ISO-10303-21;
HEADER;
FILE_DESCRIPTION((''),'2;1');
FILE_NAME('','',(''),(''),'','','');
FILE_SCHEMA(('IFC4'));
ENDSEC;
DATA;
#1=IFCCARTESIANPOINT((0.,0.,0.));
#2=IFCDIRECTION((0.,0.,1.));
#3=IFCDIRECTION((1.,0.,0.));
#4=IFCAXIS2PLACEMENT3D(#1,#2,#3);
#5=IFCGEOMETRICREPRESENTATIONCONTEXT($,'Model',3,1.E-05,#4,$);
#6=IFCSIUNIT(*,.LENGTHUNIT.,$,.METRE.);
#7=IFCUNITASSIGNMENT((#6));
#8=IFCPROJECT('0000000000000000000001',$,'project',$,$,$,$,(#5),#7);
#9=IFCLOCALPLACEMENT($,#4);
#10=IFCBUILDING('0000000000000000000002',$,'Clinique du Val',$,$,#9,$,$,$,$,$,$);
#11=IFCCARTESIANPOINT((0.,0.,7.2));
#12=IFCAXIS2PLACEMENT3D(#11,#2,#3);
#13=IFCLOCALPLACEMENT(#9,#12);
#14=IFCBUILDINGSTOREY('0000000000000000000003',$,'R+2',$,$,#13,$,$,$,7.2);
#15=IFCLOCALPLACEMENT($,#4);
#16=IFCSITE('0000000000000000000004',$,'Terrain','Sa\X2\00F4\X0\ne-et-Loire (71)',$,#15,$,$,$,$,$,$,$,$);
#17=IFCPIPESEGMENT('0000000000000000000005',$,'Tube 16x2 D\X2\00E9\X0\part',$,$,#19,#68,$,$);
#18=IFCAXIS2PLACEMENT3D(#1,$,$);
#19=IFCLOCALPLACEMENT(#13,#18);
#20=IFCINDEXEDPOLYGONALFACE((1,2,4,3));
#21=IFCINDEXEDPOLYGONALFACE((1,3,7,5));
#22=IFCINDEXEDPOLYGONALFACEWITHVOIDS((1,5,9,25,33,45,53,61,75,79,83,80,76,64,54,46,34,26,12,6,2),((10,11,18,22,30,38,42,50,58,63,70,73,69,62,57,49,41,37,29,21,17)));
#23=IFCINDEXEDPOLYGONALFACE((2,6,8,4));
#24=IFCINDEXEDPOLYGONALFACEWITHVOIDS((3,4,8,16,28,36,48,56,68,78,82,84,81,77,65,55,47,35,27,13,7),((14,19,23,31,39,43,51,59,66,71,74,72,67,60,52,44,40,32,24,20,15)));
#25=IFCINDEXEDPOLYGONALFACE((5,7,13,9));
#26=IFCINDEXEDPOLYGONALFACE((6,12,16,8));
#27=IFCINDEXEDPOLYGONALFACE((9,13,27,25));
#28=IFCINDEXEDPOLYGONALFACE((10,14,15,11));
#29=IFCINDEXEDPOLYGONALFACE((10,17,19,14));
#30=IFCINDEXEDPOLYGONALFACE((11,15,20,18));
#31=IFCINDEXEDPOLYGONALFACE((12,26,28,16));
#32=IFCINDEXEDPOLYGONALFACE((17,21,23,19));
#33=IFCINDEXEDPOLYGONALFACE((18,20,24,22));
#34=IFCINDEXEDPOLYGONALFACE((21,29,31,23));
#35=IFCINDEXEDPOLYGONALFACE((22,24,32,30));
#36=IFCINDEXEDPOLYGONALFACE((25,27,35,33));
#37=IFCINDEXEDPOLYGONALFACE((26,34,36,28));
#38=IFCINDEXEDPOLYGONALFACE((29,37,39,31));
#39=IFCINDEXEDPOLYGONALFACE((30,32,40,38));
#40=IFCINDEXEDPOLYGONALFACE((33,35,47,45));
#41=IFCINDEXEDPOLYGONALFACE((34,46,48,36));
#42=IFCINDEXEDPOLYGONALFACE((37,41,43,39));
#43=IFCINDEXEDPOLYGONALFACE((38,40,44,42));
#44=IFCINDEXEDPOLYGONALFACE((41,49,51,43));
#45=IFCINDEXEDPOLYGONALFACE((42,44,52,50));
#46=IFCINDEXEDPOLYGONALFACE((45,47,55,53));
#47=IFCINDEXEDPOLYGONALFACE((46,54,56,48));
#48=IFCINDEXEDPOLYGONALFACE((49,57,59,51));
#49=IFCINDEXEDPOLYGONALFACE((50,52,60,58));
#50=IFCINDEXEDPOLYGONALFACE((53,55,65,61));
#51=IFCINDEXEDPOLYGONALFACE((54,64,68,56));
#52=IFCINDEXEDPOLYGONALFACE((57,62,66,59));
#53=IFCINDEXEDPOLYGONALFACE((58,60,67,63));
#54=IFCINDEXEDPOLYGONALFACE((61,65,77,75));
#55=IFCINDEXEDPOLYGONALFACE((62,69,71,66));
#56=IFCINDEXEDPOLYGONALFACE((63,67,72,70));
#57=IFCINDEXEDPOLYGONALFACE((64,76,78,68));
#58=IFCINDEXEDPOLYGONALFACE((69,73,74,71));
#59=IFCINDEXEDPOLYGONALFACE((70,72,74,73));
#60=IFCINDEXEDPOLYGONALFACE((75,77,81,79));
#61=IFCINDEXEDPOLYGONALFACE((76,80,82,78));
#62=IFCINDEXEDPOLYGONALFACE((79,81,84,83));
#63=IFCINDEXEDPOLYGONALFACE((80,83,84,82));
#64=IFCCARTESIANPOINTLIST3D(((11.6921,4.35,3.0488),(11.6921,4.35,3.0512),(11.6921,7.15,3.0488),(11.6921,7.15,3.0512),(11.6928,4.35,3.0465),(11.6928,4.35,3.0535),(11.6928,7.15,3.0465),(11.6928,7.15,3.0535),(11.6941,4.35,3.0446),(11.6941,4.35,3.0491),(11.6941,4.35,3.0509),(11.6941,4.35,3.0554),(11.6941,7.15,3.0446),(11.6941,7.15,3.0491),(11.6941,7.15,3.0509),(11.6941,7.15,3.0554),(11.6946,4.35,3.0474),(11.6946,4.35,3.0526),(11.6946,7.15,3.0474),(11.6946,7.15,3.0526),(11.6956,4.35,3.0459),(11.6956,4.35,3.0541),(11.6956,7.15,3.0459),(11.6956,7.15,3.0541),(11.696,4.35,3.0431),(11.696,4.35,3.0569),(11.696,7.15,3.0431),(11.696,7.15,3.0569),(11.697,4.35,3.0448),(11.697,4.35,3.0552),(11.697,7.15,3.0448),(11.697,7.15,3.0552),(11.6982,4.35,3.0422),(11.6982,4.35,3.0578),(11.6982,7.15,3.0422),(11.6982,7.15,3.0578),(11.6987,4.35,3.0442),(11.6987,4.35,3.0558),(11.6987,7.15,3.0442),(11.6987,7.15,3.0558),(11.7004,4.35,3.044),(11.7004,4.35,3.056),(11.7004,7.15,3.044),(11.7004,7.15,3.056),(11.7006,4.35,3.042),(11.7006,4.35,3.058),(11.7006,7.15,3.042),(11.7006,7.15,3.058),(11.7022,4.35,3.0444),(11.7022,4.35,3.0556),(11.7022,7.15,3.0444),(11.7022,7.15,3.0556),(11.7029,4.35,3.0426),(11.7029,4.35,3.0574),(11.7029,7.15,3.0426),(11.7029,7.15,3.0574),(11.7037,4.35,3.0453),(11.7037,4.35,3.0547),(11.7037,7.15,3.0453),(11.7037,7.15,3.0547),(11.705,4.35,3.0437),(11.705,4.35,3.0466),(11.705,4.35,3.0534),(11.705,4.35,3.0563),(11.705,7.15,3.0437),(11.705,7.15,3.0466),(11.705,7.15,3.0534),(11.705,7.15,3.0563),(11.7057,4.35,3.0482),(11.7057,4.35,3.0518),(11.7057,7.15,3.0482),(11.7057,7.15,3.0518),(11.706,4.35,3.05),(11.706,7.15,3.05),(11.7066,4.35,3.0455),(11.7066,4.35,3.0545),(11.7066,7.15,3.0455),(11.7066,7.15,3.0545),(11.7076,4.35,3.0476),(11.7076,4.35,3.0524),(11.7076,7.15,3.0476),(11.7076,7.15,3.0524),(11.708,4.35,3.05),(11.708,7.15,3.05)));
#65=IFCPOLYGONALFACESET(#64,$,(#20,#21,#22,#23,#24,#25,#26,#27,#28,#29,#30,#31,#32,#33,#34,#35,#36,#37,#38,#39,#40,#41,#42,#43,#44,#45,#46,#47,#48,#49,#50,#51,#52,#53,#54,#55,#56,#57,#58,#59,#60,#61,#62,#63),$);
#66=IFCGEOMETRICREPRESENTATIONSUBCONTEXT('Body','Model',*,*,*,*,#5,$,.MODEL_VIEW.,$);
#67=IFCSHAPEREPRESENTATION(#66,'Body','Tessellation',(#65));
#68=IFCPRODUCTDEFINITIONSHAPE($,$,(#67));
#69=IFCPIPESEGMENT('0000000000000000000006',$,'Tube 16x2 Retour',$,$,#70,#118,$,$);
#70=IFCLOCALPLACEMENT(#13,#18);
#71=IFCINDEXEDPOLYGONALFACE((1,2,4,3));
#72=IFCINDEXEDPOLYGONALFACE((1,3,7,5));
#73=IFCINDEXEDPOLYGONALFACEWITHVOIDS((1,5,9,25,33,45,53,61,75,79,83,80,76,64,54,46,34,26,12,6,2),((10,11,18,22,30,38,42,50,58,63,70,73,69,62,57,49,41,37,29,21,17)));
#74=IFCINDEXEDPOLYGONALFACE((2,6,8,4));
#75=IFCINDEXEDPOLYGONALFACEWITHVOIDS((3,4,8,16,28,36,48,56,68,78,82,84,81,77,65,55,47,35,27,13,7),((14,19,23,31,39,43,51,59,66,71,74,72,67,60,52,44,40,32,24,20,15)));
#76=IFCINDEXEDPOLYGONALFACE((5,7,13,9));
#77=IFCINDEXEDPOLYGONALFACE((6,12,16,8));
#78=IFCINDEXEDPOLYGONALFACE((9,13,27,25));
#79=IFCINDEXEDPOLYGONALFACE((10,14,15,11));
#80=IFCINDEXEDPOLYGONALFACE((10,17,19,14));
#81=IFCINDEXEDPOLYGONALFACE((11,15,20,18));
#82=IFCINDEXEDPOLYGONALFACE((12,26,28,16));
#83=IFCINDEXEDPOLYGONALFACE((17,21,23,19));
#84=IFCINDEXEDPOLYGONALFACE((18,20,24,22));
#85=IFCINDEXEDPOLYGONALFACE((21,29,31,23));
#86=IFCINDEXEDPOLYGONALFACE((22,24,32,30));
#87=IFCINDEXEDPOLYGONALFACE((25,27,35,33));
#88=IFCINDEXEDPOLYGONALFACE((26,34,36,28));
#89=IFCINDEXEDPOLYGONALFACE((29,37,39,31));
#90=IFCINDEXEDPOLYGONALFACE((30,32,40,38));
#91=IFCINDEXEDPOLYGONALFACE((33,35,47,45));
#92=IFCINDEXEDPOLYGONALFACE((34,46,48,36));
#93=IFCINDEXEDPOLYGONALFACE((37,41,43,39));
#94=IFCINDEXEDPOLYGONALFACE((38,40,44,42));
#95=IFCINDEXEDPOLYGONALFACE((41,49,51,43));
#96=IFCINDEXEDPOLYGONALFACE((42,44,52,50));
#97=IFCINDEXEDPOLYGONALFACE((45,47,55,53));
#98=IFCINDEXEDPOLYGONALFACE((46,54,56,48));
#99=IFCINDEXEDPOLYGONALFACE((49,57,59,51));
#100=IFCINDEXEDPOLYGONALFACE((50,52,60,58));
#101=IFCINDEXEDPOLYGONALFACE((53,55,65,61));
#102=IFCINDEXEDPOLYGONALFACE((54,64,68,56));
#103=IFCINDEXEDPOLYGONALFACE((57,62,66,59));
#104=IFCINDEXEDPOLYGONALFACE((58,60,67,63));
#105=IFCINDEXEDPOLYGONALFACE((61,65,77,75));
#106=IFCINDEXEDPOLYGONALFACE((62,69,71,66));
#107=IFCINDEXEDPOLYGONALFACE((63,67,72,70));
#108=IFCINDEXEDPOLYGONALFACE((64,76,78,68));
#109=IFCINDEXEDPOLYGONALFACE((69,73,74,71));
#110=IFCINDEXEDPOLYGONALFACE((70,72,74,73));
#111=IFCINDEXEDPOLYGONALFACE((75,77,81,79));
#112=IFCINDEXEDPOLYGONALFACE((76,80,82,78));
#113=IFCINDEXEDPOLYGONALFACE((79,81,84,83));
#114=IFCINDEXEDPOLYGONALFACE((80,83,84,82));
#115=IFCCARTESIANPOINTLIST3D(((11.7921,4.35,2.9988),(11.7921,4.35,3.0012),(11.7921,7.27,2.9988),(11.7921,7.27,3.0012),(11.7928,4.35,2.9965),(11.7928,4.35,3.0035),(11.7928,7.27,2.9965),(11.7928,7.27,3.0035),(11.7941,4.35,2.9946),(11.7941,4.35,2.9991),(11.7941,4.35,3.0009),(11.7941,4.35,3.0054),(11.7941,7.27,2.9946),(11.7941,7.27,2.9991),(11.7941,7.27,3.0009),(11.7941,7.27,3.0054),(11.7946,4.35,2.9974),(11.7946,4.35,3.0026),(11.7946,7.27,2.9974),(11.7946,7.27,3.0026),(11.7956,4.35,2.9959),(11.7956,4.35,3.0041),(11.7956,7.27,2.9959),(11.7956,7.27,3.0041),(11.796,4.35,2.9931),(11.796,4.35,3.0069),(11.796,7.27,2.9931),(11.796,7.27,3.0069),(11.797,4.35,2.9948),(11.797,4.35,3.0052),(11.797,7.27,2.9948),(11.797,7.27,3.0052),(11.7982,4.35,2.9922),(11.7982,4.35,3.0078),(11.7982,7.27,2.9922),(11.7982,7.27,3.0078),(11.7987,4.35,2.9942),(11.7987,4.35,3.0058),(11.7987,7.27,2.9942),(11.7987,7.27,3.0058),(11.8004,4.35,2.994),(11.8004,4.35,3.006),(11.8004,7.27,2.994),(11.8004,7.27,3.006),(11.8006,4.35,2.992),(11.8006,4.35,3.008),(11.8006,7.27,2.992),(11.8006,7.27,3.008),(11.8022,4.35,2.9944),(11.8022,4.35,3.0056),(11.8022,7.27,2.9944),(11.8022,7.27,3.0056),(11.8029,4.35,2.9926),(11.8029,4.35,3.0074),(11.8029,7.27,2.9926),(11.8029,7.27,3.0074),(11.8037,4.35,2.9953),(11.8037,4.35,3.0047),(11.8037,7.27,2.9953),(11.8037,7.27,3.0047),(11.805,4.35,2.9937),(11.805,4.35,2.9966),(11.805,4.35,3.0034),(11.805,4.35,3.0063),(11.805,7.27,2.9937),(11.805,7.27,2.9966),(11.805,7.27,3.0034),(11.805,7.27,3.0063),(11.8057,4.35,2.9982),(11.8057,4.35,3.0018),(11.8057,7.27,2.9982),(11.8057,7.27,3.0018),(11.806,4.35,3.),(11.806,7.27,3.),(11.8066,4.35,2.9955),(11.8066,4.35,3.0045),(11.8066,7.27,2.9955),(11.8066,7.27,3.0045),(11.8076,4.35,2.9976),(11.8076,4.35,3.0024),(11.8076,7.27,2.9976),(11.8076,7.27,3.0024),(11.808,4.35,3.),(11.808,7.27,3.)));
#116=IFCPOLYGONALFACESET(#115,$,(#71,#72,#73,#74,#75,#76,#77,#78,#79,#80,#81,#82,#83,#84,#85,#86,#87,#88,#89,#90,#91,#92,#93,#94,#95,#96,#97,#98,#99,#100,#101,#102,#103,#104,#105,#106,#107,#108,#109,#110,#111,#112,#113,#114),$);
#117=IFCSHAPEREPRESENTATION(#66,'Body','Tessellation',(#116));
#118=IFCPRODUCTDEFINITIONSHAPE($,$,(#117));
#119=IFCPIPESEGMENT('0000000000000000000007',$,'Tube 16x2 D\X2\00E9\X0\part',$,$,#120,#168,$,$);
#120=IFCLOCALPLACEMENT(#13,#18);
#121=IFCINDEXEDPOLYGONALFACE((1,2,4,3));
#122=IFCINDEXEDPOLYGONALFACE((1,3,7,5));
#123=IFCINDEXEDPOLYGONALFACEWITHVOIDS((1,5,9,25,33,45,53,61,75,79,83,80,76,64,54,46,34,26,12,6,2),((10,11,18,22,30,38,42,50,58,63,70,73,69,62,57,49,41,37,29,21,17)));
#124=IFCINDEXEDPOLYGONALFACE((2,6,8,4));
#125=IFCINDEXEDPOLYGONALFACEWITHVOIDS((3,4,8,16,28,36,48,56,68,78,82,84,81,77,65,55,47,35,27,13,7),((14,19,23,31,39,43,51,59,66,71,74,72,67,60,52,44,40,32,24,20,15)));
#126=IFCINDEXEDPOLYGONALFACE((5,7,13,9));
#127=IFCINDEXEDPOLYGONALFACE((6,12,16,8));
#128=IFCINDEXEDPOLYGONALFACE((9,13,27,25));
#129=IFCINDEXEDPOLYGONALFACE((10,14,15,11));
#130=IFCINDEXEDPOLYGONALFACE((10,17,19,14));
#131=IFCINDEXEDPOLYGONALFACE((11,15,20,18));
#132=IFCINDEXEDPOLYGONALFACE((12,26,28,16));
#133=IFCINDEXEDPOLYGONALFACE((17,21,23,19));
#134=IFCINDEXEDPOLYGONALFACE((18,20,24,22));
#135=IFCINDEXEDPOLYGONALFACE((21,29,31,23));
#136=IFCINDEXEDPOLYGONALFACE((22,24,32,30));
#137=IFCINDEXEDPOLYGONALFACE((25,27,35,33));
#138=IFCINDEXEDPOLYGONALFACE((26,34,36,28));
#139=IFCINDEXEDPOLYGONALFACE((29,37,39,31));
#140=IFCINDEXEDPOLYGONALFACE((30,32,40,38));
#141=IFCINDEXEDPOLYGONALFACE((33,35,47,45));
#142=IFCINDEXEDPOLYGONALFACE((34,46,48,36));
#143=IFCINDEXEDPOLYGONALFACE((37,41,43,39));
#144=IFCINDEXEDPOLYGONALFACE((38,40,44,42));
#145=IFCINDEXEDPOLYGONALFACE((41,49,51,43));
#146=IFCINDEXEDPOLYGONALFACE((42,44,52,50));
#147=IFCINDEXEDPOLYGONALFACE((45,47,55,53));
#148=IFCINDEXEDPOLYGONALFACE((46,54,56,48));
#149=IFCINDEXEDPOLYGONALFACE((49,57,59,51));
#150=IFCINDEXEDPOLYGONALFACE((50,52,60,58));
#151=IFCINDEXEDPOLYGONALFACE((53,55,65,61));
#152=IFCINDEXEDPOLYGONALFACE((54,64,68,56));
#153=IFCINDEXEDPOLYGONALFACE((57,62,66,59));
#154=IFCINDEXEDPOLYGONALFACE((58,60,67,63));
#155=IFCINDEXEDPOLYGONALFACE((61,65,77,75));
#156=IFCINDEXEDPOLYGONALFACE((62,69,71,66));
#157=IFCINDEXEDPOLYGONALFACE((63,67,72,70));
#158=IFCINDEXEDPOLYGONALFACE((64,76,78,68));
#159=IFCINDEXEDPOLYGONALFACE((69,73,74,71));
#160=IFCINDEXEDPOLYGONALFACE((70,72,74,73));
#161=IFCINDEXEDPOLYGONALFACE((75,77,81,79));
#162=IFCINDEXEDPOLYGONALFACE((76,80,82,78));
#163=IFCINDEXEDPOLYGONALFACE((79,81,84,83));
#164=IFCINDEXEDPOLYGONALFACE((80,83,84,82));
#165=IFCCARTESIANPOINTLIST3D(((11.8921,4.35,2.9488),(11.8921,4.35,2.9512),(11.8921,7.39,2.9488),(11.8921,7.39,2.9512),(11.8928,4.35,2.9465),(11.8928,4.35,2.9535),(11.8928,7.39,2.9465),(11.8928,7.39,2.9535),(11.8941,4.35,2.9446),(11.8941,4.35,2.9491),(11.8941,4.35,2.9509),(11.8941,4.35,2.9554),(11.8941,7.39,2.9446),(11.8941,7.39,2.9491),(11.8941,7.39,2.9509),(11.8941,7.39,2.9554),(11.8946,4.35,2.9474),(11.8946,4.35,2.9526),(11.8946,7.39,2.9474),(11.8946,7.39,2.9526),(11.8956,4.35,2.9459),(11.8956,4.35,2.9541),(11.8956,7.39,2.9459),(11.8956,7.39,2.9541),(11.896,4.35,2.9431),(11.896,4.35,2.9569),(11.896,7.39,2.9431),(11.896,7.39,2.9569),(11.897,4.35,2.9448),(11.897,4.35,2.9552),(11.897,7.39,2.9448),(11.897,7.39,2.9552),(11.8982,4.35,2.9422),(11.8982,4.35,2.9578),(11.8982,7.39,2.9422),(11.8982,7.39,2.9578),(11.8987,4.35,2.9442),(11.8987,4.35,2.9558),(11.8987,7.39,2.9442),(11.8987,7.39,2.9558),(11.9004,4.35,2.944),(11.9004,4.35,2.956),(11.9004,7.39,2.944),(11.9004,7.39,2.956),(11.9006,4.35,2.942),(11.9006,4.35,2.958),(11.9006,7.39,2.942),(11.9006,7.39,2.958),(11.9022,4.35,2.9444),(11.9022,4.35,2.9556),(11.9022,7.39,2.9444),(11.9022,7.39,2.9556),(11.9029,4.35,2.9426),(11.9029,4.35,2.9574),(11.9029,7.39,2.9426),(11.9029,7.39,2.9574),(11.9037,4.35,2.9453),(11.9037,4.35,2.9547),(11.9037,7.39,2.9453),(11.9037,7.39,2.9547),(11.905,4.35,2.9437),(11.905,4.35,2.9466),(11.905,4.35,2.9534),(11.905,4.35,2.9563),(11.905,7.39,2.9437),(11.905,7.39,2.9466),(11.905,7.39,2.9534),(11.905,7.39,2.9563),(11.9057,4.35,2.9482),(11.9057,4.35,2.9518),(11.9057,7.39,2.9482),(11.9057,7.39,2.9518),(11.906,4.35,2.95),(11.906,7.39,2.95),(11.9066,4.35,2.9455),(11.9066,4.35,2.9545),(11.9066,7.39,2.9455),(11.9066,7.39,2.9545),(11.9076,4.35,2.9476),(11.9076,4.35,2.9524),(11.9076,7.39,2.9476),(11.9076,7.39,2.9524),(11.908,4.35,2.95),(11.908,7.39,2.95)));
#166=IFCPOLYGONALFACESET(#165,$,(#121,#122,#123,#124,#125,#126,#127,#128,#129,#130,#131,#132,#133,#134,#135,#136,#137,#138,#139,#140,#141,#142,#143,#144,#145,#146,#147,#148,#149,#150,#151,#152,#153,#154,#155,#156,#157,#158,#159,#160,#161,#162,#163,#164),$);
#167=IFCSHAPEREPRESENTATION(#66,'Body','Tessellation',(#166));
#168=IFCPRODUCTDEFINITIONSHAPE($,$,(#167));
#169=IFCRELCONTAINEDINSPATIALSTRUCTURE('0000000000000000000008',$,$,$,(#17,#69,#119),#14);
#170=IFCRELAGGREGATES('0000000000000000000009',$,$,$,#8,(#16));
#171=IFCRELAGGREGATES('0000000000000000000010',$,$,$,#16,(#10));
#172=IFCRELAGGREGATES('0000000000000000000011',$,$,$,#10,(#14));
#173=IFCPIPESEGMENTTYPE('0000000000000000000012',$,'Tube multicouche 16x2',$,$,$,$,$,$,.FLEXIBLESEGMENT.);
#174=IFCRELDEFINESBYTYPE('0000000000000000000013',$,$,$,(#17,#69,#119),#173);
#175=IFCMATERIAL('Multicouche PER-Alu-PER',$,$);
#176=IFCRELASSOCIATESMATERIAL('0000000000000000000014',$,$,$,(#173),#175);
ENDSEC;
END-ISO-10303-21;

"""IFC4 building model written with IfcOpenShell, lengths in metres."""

from ifc_helpers import new_model, si_unit, frame, origin_with_axes, place, context, subcontext, project, spatial, hollow_circle, extrude, material, type_object, element, save


model = new_model("IFC4")

# Units and contexts
model_context = context("Model", 3, precision=1e-05, world=origin_with_axes())
body_context = subcontext(model_context, "Body", "Model", "MODEL_VIEW")
ifc_project = project(units=[si_unit("LENGTHUNIT", "METRE")], contexts=[model_context])

# Site, building, storey
site_placement = place(None, origin_with_axes())
site = spatial("IfcSite", under=ifc_project, at=site_placement, Name="Terrain", Description="Saône-et-Loire (71)")
building_placement = place(None, origin_with_axes())
building = spatial("IfcBuilding", under=site, at=building_placement, Name="Clinique du Val")
storey_placement = place(building_placement, frame((0.0, 0.0, 7.2), z_axis=(0.0, 0.0, 1.0), x_axis=(1.0, 0.0, 0.0)))
storey = spatial("IfcBuildingStorey", under=building, at=storey_placement, Name="R+2", Elevation=7.2)

# Pipe segments
ifc_material_1 = material(Name="Multicouche PER-Alu-PER")
pipe_segment_type_1 = type_object("IfcPipeSegmentType", Name="Tube multicouche 16x2", PredefinedType="FLEXIBLESEGMENT", material=ifc_material_1)
pipe_segment_1_placement = place(storey_placement, frame((11.7, 7.15, 3.05), z_axis=(0.0, -1.0, 0.0), x_axis=(1.0, 0.0, 0.0)))
element("IfcPipeSegment", 1, at=pipe_segment_1_placement, inside=storey, type_object=pipe_segment_type_1, Name="Tube 16x2 Départ", context=body_context, shape_type="SweptSolid", body=[
    extrude(hollow_circle(Radius=0.008, WallThickness=0.002), origin_with_axes(), (0.0, 0.0, 1.0), 2.8),
])
pipe_segment_2_placement = place(storey_placement, frame((11.8, 7.27, 3.0), z_axis=(0.0, -1.0, 0.0), x_axis=(1.0, 0.0, 0.0)))
element("IfcPipeSegment", 2, at=pipe_segment_2_placement, inside=storey, type_object=pipe_segment_type_1, Name="Tube 16x2 Retour", context=body_context, shape_type="SweptSolid", body=[
    extrude(hollow_circle(Radius=0.008, WallThickness=0.002), origin_with_axes(), (0.0, 0.0, 1.0), 2.92),
])
pipe_segment_3_placement = place(storey_placement, frame((11.9, 7.39, 2.95), z_axis=(0.0, -1.0, 0.0), x_axis=(1.0, 0.0, 0.0)))
element("IfcPipeSegment", 3, at=pipe_segment_3_placement, inside=storey, type_object=pipe_segment_type_1, Name="Tube 16x2 Départ", context=body_context, shape_type="SweptSolid", body=[
    extrude(hollow_circle(Radius=0.008, WallThickness=0.002), origin_with_axes(), (0.0, 0.0, 1.0), 3.04),
])

save(model, "model.ifc")
